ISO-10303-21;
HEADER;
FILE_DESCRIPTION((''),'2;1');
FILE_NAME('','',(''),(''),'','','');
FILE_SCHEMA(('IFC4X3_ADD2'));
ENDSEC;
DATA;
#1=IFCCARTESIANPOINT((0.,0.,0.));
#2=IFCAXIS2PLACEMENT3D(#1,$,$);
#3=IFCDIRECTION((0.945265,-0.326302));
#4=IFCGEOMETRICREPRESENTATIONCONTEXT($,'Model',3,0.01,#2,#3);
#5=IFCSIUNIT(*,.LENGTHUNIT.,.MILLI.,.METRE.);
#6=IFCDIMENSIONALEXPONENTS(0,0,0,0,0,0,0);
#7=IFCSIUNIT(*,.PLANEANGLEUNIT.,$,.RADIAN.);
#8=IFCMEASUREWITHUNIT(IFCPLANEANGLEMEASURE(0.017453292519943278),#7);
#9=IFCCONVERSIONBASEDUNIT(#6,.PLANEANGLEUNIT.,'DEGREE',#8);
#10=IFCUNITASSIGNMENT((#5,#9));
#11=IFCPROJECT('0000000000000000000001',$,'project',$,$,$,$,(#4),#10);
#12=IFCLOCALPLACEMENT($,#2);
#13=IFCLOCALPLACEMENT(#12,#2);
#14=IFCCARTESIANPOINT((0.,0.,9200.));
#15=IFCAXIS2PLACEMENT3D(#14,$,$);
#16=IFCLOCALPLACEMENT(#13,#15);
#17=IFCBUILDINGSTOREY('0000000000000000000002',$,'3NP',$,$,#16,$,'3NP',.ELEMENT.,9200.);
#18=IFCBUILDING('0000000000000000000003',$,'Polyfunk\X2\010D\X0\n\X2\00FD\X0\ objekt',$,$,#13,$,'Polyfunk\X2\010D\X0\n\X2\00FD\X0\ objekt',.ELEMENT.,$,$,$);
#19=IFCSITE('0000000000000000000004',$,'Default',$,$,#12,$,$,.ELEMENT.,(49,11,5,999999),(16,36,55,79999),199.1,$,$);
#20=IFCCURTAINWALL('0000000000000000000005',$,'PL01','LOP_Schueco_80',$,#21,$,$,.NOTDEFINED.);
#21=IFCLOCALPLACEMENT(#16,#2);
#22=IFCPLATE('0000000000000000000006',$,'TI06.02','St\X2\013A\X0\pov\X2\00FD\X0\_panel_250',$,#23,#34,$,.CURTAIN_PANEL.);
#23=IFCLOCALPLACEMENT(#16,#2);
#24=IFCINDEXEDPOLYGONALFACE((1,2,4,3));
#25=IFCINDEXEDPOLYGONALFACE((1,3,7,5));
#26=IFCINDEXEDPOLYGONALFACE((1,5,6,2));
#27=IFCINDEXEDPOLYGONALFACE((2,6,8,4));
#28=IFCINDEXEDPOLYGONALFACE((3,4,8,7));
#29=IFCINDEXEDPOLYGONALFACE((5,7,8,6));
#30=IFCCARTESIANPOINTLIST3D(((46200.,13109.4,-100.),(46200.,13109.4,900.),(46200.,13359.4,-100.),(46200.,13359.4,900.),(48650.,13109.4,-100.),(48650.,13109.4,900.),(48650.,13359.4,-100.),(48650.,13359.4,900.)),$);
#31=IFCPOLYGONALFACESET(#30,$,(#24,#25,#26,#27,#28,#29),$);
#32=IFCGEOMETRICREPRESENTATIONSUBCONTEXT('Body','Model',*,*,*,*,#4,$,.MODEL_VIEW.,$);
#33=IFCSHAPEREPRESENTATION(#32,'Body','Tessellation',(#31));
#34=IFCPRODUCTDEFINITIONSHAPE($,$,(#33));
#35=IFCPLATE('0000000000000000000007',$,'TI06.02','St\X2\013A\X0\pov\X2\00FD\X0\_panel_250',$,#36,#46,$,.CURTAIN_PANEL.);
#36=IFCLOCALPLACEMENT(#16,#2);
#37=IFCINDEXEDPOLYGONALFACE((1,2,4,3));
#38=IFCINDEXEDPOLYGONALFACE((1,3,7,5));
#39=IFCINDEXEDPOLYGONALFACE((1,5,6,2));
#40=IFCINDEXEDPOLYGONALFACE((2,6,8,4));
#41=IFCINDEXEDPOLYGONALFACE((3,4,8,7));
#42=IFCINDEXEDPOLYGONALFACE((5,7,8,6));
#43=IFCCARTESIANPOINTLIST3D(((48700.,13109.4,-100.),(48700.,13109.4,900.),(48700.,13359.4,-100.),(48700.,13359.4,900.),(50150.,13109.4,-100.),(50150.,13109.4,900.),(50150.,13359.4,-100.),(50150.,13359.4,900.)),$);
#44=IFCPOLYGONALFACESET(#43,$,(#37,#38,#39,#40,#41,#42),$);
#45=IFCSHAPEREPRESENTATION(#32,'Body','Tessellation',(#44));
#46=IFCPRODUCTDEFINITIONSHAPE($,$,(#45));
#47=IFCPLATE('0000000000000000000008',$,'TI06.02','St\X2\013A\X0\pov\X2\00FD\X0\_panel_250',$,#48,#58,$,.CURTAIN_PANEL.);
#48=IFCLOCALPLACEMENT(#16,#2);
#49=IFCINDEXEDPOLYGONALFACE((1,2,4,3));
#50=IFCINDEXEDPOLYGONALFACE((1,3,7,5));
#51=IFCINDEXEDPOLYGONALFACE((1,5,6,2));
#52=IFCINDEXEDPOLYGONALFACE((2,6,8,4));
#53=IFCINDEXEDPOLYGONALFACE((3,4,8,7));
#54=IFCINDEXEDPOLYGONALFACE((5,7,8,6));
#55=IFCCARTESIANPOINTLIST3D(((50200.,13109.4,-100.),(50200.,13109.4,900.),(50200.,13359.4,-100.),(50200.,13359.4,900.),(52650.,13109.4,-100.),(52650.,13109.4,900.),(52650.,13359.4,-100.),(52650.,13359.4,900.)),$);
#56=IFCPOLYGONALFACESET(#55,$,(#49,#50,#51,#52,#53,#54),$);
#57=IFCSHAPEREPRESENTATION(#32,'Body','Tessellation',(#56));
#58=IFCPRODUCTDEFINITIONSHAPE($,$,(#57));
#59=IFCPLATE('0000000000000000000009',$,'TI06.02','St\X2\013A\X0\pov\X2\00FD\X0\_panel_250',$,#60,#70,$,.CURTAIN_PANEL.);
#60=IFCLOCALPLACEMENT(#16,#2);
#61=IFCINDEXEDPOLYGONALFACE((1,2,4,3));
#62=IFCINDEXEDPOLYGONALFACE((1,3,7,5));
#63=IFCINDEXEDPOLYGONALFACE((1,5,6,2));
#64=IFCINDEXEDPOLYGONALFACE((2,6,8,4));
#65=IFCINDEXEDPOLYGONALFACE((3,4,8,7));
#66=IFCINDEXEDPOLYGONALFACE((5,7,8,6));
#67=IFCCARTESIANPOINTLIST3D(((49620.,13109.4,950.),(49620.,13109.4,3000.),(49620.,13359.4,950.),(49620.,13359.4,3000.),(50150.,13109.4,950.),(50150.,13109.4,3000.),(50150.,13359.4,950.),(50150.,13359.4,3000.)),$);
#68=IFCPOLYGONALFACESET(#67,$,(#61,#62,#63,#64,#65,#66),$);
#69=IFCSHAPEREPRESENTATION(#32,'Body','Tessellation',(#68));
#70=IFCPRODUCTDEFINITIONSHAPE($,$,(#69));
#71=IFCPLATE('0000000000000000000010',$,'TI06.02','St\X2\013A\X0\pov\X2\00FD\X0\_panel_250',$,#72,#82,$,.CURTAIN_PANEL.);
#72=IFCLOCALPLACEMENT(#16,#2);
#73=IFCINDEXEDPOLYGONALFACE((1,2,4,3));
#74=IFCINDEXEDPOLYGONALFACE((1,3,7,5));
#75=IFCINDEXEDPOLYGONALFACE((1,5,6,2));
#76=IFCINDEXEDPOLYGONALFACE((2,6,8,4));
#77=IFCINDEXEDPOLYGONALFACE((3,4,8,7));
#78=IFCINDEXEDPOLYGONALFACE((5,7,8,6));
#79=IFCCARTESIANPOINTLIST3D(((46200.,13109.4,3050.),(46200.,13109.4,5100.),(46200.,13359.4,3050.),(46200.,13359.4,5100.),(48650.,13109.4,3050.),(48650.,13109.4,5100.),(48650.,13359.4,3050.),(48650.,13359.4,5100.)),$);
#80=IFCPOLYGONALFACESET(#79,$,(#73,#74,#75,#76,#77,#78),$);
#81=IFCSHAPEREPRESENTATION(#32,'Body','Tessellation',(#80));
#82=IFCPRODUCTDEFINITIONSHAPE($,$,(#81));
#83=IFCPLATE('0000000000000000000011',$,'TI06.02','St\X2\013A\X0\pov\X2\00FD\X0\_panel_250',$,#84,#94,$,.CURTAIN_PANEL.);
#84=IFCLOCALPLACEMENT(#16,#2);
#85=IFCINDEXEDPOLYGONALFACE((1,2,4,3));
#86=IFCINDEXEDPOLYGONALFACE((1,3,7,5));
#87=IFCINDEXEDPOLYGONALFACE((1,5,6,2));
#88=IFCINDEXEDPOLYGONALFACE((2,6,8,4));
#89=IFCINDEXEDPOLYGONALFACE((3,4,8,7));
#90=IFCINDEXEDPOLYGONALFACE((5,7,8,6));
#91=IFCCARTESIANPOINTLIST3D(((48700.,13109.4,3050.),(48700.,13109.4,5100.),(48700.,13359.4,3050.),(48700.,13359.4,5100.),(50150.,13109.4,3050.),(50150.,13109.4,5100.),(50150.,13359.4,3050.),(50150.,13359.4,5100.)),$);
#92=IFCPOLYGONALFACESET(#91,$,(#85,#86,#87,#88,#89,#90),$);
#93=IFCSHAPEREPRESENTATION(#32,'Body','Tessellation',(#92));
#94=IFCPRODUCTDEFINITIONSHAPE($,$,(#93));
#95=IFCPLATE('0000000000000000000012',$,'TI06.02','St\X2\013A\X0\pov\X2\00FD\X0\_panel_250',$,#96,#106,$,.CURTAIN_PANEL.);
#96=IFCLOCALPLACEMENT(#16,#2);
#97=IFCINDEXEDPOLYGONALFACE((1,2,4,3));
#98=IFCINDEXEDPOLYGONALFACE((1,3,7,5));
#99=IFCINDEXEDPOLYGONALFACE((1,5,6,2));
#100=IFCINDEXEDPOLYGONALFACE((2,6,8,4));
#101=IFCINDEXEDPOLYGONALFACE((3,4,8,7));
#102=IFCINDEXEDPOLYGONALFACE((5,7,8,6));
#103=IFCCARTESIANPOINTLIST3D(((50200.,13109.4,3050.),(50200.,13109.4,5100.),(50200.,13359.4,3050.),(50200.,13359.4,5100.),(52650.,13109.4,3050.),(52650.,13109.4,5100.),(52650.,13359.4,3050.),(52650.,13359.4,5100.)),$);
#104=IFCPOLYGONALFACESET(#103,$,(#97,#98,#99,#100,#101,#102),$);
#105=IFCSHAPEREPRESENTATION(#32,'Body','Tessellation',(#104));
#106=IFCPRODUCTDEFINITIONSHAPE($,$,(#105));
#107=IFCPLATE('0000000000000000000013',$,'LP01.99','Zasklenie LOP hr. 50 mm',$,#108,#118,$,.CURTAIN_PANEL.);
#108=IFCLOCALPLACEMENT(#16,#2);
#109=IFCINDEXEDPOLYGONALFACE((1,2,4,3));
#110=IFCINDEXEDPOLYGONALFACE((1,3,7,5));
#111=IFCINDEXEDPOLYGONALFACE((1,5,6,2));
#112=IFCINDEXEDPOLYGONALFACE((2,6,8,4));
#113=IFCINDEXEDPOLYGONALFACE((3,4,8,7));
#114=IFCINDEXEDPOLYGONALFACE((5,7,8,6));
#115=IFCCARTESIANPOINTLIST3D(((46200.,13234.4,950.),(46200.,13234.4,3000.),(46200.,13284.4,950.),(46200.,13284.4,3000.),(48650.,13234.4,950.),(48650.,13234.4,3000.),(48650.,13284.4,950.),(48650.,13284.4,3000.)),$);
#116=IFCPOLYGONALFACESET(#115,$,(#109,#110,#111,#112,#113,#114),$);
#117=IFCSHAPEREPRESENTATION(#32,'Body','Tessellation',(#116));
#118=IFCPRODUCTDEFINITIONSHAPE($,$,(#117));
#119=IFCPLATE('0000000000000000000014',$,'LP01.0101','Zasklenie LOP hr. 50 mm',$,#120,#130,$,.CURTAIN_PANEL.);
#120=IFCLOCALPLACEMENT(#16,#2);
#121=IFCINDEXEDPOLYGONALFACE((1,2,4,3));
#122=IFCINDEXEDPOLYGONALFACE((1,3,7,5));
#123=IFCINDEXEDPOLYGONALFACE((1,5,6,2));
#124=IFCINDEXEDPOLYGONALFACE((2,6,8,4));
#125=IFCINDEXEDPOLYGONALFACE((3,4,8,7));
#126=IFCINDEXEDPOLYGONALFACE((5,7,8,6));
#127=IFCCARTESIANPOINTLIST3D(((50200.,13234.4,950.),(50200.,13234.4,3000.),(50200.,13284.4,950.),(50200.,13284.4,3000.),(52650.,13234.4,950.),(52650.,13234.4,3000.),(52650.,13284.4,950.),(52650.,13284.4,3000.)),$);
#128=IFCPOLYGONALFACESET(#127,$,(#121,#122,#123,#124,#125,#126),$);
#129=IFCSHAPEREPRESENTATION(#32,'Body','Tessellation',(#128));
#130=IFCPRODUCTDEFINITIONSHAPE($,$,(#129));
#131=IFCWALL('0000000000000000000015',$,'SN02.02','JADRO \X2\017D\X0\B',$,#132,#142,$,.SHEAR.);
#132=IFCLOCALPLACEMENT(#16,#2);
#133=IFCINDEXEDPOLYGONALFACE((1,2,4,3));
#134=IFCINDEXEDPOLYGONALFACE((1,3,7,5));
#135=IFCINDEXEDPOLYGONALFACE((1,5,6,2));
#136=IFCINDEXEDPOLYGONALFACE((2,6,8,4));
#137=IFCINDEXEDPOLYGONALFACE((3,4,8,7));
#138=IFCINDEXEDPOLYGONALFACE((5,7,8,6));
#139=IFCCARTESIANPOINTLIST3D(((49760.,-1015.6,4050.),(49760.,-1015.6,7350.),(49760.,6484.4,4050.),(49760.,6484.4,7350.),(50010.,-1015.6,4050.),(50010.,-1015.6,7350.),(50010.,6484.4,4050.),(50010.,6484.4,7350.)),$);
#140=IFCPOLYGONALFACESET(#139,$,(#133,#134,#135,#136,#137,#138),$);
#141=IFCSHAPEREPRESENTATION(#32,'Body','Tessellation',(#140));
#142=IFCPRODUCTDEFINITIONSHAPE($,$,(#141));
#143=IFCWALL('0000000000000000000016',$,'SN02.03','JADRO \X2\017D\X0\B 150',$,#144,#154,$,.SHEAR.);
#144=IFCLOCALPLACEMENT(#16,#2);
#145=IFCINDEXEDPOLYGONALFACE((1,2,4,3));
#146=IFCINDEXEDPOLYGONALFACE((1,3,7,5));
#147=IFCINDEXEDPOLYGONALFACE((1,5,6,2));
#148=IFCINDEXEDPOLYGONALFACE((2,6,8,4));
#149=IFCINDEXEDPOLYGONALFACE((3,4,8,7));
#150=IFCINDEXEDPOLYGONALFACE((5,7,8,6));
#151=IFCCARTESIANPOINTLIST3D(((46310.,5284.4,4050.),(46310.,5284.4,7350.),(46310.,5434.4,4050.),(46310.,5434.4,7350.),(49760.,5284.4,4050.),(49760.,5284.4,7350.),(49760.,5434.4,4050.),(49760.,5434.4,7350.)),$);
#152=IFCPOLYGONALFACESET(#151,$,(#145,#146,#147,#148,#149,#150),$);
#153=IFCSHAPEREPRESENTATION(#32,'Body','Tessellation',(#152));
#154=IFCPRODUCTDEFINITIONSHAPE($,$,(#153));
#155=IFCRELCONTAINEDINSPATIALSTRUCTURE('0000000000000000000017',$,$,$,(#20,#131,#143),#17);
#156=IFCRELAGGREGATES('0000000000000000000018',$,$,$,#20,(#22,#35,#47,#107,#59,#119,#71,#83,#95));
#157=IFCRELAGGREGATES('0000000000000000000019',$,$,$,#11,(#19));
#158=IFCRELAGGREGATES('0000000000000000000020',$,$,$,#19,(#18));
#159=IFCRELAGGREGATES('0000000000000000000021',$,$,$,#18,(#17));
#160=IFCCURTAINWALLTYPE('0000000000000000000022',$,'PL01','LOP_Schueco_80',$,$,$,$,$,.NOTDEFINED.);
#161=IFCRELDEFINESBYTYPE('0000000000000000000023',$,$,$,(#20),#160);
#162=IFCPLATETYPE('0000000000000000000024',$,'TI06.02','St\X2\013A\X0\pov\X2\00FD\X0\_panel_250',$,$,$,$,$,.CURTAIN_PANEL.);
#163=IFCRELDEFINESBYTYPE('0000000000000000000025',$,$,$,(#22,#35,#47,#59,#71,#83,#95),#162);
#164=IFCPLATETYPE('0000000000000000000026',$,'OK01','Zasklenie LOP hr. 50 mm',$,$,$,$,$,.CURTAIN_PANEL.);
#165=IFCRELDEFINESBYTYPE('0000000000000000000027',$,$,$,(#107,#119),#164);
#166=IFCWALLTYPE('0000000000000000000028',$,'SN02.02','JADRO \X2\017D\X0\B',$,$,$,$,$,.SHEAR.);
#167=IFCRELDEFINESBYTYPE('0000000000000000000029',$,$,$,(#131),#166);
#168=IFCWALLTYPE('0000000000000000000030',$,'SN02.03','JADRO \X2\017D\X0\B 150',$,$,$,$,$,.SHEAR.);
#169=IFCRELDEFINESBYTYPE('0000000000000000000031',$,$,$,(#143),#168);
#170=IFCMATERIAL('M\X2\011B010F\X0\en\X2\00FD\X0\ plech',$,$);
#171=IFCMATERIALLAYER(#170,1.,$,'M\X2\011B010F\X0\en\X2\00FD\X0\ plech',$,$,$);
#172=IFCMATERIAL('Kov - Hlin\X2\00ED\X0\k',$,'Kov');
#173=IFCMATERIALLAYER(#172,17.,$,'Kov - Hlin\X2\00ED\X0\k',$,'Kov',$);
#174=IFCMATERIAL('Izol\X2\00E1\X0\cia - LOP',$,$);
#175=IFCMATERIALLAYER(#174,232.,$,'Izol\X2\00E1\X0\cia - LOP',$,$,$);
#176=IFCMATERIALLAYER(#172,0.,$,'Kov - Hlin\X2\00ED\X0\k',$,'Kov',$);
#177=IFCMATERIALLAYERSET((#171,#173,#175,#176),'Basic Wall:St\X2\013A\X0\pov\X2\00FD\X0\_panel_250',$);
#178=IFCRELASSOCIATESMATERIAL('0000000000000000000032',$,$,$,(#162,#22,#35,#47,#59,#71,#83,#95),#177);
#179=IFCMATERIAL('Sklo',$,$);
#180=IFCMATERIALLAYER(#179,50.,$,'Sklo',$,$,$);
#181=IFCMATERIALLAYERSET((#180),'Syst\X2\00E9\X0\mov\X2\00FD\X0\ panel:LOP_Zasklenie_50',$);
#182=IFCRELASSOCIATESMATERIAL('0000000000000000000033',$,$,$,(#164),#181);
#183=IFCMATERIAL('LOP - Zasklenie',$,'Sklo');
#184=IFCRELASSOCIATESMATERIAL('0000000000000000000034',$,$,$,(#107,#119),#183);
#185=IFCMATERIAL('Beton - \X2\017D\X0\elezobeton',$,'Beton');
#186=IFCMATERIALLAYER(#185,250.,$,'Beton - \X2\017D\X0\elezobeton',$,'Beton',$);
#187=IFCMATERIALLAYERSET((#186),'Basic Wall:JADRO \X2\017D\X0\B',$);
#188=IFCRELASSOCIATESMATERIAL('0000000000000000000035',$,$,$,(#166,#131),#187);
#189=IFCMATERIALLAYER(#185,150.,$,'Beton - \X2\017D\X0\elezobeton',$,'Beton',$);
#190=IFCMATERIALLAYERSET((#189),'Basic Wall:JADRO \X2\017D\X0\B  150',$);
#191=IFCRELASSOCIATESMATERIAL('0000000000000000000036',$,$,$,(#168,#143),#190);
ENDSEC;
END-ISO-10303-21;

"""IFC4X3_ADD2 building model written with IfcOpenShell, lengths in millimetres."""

from ifc_helpers import new_model, entity, si_unit, converted_unit, direction, frame, frame_2d, origin, origin_2d_with_axis, place, context, subcontext, project, spatial, polyline, rectangle, extrude, clip, bounded_halfspace, source, transform, mapped, material, layer, layer_set, layer_usage, type_object, type_shapes, element, aggregate, save


model = new_model("IFC4X3_ADD2")

# Units and contexts
model_context = context("Model", 3, precision=0.01, world=origin(), true_north=direction((0.945265, -0.326302)))
body_context = subcontext(model_context, "Body", "Model", "MODEL_VIEW")
ifc_project = project(units=[si_unit("LENGTHUNIT", "METRE", prefix="MILLI"), converted_unit("PLANEANGLEUNIT", "DEGREE", entity("IfcPlaneAngleMeasure", 0.017453292519943278), si_unit("PLANEANGLEUNIT", "RADIAN"), dimensions=[0, 0, 0, 0, 0, 0, 0])], contexts=[model_context])

# Site, building, storey
site_placement = place(None, origin())
site = spatial("IfcSite", under=ifc_project, at=site_placement, Name="Default", CompositionType="ELEMENT", RefLatitude=(49, 11, 5, 999999), RefLongitude=(16, 36, 55, 79999), RefElevation=199.1)
building_placement = place(site_placement, origin())
building = spatial("IfcBuilding", under=site, at=building_placement, Name="Polyfunkčný objekt", LongName="Polyfunkčný objekt", CompositionType="ELEMENT")
storey_placement = place(building_placement, frame((0.0, 0.0, 9200.0)))
storey = spatial("IfcBuildingStorey", under=building, at=storey_placement, Name="3NP", LongName="3NP", CompositionType="ELEMENT", Elevation=9200.0)

# Curtain wall, plates
curtain_wall_type = type_object("IfcCurtainWallType", Name="PL01", Description="LOP_Schueco_80", PredefinedType="NOTDEFINED")
curtain_wall_placement = place(storey_placement, frame((0.0, 0.0, -9200.0)))
curtain_wall = element("IfcCurtainWall", 1, at=curtain_wall_placement, inside=storey, type_object=curtain_wall_type, Name="PL01", Description="LOP_Schueco_80", PredefinedType="NOTDEFINED")
ifc_material_1 = material(Name="Měďený plech")
ifc_layer_1 = layer(ifc_material_1, 1.0, Name="Měďený plech")
ifc_material_2 = material(Name="Kov - Hliník", Category="Kov")
ifc_layer_2 = layer(ifc_material_2, 17.0, Name="Kov - Hliník", Category="Kov")
ifc_material_3 = material(Name="Izolácia - LOP")
ifc_layer_3 = layer(ifc_material_3, 232.0, Name="Izolácia - LOP")
ifc_layer_4 = layer(ifc_material_2, 0.0, Name="Kov - Hliník", Category="Kov")
ifc_layer_set_1 = layer_set([ifc_layer_1, ifc_layer_2, ifc_layer_3, ifc_layer_4], Name="Basic Wall:Stĺpový_panel_250")
ifc_layer_usage_1 = layer_usage(ifc_layer_set_1, "AXIS2", "NEGATIVE", 125.0)
plate_type_1 = type_object("IfcPlateType", Name="TI06.02", Description="Stĺpový_panel_250", PredefinedType="CURTAIN_PANEL", material=ifc_layer_set_1)
plate_1_placement = place(storey_placement, frame((46200.0, 13234.4, -100.0)))
plate_1 = element("IfcPlate", 2, at=plate_1_placement, type_object=plate_type_1, material=ifc_layer_usage_1, Name="TI06.02", Description="Stĺpový_panel_250", PredefinedType="CURTAIN_PANEL", context=body_context, shape_type="SweptSolid", body=[
    extrude(rectangle(XDim=250.0, YDim=2450.0, at=frame_2d((0.0, 0.0), x_axis=(1.0, 0.0))), frame((1225.0, 0.0, 0.0), z_axis=(0.0, 0.0, 1.0), x_axis=(0.0, 1.0, 0.0)), (0.0, 0.0, 1.0), 1000.0),
])
ifc_layer_usage_2 = layer_usage(ifc_layer_set_1, "AXIS2", "NEGATIVE", 125.0)
plate_2_placement = place(storey_placement, frame((48700.0, 13234.4, -100.0)))
plate_2 = element("IfcPlate", 3, at=plate_2_placement, type_object=plate_type_1, material=ifc_layer_usage_2, Name="TI06.02", Description="Stĺpový_panel_250", PredefinedType="CURTAIN_PANEL", context=body_context, shape_type="SweptSolid", body=[
    extrude(rectangle(XDim=250.0, YDim=1450.0, at=frame_2d((0.0, 0.0), x_axis=(1.0, 0.0))), frame((725.0, 0.0, 0.0), z_axis=(0.0, 0.0, 1.0), x_axis=(0.0, 1.0, 0.0)), (0.0, 0.0, 1.0), 1000.0),
])
ifc_layer_usage_3 = layer_usage(ifc_layer_set_1, "AXIS2", "NEGATIVE", 125.0)
plate_3_placement = place(storey_placement, frame((50200.0, 13234.4, -100.0)))
plate_3 = element("IfcPlate", 4, at=plate_3_placement, type_object=plate_type_1, material=ifc_layer_usage_3, Name="TI06.02", Description="Stĺpový_panel_250", PredefinedType="CURTAIN_PANEL", context=body_context, shape_type="SweptSolid", body=[
    extrude(rectangle(XDim=250.0, YDim=2450.0, at=origin_2d_with_axis()), frame((1225.0, 0.0, 0.0), z_axis=(0.0, 0.0, 1.0), x_axis=(0.0, 1.0, 0.0)), (0.0, 0.0, 1.0), 1000.0),
])
ifc_layer_usage_4 = layer_usage(ifc_layer_set_1, "AXIS2", "NEGATIVE", 125.0)
plate_4_placement = place(storey_placement, frame((49620.0, 13234.4, 950.0)))
plate_4 = element("IfcPlate", 5, at=plate_4_placement, type_object=plate_type_1, material=ifc_layer_usage_4, Name="TI06.02", Description="Stĺpový_panel_250", PredefinedType="CURTAIN_PANEL", context=body_context, shape_type="SweptSolid", body=[
    extrude(rectangle(XDim=250.0, YDim=530.0, at=frame_2d((0.0, 0.0), x_axis=(1.0, 0.0))), frame((265.0, 0.0, 0.0), z_axis=(0.0, 0.0, 1.0), x_axis=(0.0, 1.0, 0.0)), (0.0, 0.0, 1.0), 2050.0),
])
ifc_layer_usage_5 = layer_usage(ifc_layer_set_1, "AXIS2", "NEGATIVE", 125.0)
plate_5_placement = place(storey_placement, frame((46200.0, 13234.4, 3050.0)))
plate_5 = element("IfcPlate", 6, at=plate_5_placement, type_object=plate_type_1, material=ifc_layer_usage_5, Name="TI06.02", Description="Stĺpový_panel_250", PredefinedType="CURTAIN_PANEL", context=body_context, shape_type="SweptSolid", body=[
    extrude(rectangle(XDim=250.0, YDim=2450.0, at=frame_2d((0.0, 0.0), x_axis=(1.0, 0.0))), frame((1225.0, 0.0, 0.0), z_axis=(0.0, 0.0, 1.0), x_axis=(0.0, 1.0, 0.0)), (0.0, 0.0, 1.0), 2050.0),
])
ifc_layer_usage_6 = layer_usage(ifc_layer_set_1, "AXIS2", "NEGATIVE", 125.0)
plate_6_placement = place(storey_placement, frame((48700.0, 13234.4, 3050.0)))
plate_6 = element("IfcPlate", 7, at=plate_6_placement, type_object=plate_type_1, material=ifc_layer_usage_6, Name="TI06.02", Description="Stĺpový_panel_250", PredefinedType="CURTAIN_PANEL", context=body_context, shape_type="SweptSolid", body=[
    extrude(rectangle(XDim=250.0, YDim=1450.0, at=frame_2d((0.0, 0.0), x_axis=(1.0, 0.0))), frame((725.0, 0.0, 0.0), z_axis=(0.0, 0.0, 1.0), x_axis=(0.0, 1.0, 0.0)), (0.0, 0.0, 1.0), 2050.0),
])
ifc_layer_usage_7 = layer_usage(ifc_layer_set_1, "AXIS2", "NEGATIVE", 125.0)
plate_7_placement = place(storey_placement, frame((50200.0, 13234.4, 3050.0)))
plate_7 = element("IfcPlate", 8, at=plate_7_placement, type_object=plate_type_1, material=ifc_layer_usage_7, Name="TI06.02", Description="Stĺpový_panel_250", PredefinedType="CURTAIN_PANEL", context=body_context, shape_type="SweptSolid", body=[
    extrude(rectangle(XDim=250.0, YDim=2450.0, at=origin_2d_with_axis()), frame((1225.0, 0.0, 0.0), z_axis=(0.0, 0.0, 1.0), x_axis=(0.0, 1.0, 0.0)), (0.0, 0.0, 1.0), 2050.0),
])
ifc_material_4 = material(Name="LOP - Zasklenie", Category="Sklo")
ifc_material_5 = material(Name="Sklo")
ifc_layer_5 = layer(ifc_material_5, 50.0, Name="Sklo")
ifc_layer_set_2 = layer_set([ifc_layer_5], Name="Systémový panel:LOP_Zasklenie_50")
plate_type_2 = type_object("IfcPlateType", Name="OK01", Description="Zasklenie LOP hr. 50 mm", PredefinedType="CURTAIN_PANEL", material=ifc_layer_set_2)
shared_shape_1 = source(origin(), body_context, "Body", "SweptSolid", [
    extrude(rectangle(XDim=50.0, YDim=2450.0, at=origin_2d_with_axis()), frame((0.0, 25.0, 0.0), z_axis=(0.0, 0.0, 1.0), x_axis=(0.0, 1.0, 0.0)), (0.0, 0.0, 1.0), 2050.0),
])
type_shapes(plate_type_2, [shared_shape_1])
plate_8_placement = place(curtain_wall_placement, frame((47425.0, 13234.4, 10150.0)))
plate_8 = element("IfcPlate", 9, at=plate_8_placement, type_object=plate_type_2, material=ifc_material_4, Name="LP01.99", Description="Zasklenie LOP hr. 50 mm", PredefinedType="CURTAIN_PANEL", context=body_context, shape_type="MappedRepresentation", body=[
    mapped(shared_shape_1, transform((0.0, 0.0, 0.0), scale=1.0)),
])
plate_9_placement = place(curtain_wall_placement, frame((51425.0, 13234.4, 10150.0)))
plate_9 = element("IfcPlate", 10, at=plate_9_placement, type_object=plate_type_2, material=ifc_material_4, Name="LP01.0101", Description="Zasklenie LOP hr. 50 mm", PredefinedType="CURTAIN_PANEL", context=body_context, shape_type="MappedRepresentation", body=[
    mapped(shared_shape_1, transform((0.0, 0.0, 0.0), scale=1.0)),
])

# Walls
ifc_material_6 = material(Name="Beton - Železobeton", Category="Beton")
ifc_layer_6 = layer(ifc_material_6, 250.0, Name="Beton - Železobeton", Category="Beton")
ifc_layer_set_3 = layer_set([ifc_layer_6], Name="Basic Wall:JADRO ŽB")
wall_type_1 = type_object("IfcWallType", Name="SN02.02", Description="JADRO ŽB", PredefinedType="SHEAR", material=ifc_layer_set_3)
wall_1_placement = place(storey_placement, frame((49885.0, 6484.4, 4050.0), z_axis=(0.0, 0.0, 1.0), x_axis=(0.0, -1.0, 0.0)))
element("IfcWall", 11, at=wall_1_placement, inside=storey, type_object=wall_type_1, material=ifc_layer_set_3, Name="SN02.02", Description="JADRO ŽB", PredefinedType="SHEAR", context=body_context, shape_type="Clipping", body=[
    clip(extrude(rectangle(XDim=7500.0, YDim=250.0, at=frame_2d((3750.0, 0.0), x_axis=(-1.0, 0.0))), origin(), (0.0, 0.0, 1.0), 3300.0), bounded_halfspace(frame((0.0, -125.0, 3300.0), z_axis=(0.0, 0.0, -1.0), x_axis=(1.0, 0.0, 0.0)), True, frame((0.0, -125.0, 3300.0)), polyline([(0.0, 0.0), (250.0, 0.0), (1050.0, 0.0), (1200.0, 0.0), (7500.0, 0.0), (7500.0, 250.0), (0.0, 250.0), (0.0, 0.0)]))),
])
ifc_layer_7 = layer(ifc_material_6, 150.0, Name="Beton - Železobeton", Category="Beton")
ifc_layer_set_4 = layer_set([ifc_layer_7], Name="Basic Wall:JADRO ŽB  150")
wall_type_2 = type_object("IfcWallType", Name="SN02.03", Description="JADRO ŽB 150", PredefinedType="SHEAR", material=ifc_layer_set_4)
wall_2_placement = place(storey_placement, frame((46310.0, 5359.4, 4050.0)))
element("IfcWall", 12, at=wall_2_placement, inside=storey, type_object=wall_type_2, material=ifc_layer_set_4, Name="SN02.03", Description="JADRO ŽB 150", PredefinedType="SHEAR", context=body_context, shape_type="SweptSolid", body=[
    extrude(rectangle(XDim=3450.0, YDim=150.0, at=frame_2d((1725.0, 0.0), x_axis=(-1.0, 0.0))), origin(), (0.0, 0.0, 1.0), 3300.0),
])

aggregate(curtain_wall, [plate_1, plate_2, plate_3, plate_8, plate_4, plate_9, plate_5, plate_6, plate_7])

save(model, "model.ifc")
